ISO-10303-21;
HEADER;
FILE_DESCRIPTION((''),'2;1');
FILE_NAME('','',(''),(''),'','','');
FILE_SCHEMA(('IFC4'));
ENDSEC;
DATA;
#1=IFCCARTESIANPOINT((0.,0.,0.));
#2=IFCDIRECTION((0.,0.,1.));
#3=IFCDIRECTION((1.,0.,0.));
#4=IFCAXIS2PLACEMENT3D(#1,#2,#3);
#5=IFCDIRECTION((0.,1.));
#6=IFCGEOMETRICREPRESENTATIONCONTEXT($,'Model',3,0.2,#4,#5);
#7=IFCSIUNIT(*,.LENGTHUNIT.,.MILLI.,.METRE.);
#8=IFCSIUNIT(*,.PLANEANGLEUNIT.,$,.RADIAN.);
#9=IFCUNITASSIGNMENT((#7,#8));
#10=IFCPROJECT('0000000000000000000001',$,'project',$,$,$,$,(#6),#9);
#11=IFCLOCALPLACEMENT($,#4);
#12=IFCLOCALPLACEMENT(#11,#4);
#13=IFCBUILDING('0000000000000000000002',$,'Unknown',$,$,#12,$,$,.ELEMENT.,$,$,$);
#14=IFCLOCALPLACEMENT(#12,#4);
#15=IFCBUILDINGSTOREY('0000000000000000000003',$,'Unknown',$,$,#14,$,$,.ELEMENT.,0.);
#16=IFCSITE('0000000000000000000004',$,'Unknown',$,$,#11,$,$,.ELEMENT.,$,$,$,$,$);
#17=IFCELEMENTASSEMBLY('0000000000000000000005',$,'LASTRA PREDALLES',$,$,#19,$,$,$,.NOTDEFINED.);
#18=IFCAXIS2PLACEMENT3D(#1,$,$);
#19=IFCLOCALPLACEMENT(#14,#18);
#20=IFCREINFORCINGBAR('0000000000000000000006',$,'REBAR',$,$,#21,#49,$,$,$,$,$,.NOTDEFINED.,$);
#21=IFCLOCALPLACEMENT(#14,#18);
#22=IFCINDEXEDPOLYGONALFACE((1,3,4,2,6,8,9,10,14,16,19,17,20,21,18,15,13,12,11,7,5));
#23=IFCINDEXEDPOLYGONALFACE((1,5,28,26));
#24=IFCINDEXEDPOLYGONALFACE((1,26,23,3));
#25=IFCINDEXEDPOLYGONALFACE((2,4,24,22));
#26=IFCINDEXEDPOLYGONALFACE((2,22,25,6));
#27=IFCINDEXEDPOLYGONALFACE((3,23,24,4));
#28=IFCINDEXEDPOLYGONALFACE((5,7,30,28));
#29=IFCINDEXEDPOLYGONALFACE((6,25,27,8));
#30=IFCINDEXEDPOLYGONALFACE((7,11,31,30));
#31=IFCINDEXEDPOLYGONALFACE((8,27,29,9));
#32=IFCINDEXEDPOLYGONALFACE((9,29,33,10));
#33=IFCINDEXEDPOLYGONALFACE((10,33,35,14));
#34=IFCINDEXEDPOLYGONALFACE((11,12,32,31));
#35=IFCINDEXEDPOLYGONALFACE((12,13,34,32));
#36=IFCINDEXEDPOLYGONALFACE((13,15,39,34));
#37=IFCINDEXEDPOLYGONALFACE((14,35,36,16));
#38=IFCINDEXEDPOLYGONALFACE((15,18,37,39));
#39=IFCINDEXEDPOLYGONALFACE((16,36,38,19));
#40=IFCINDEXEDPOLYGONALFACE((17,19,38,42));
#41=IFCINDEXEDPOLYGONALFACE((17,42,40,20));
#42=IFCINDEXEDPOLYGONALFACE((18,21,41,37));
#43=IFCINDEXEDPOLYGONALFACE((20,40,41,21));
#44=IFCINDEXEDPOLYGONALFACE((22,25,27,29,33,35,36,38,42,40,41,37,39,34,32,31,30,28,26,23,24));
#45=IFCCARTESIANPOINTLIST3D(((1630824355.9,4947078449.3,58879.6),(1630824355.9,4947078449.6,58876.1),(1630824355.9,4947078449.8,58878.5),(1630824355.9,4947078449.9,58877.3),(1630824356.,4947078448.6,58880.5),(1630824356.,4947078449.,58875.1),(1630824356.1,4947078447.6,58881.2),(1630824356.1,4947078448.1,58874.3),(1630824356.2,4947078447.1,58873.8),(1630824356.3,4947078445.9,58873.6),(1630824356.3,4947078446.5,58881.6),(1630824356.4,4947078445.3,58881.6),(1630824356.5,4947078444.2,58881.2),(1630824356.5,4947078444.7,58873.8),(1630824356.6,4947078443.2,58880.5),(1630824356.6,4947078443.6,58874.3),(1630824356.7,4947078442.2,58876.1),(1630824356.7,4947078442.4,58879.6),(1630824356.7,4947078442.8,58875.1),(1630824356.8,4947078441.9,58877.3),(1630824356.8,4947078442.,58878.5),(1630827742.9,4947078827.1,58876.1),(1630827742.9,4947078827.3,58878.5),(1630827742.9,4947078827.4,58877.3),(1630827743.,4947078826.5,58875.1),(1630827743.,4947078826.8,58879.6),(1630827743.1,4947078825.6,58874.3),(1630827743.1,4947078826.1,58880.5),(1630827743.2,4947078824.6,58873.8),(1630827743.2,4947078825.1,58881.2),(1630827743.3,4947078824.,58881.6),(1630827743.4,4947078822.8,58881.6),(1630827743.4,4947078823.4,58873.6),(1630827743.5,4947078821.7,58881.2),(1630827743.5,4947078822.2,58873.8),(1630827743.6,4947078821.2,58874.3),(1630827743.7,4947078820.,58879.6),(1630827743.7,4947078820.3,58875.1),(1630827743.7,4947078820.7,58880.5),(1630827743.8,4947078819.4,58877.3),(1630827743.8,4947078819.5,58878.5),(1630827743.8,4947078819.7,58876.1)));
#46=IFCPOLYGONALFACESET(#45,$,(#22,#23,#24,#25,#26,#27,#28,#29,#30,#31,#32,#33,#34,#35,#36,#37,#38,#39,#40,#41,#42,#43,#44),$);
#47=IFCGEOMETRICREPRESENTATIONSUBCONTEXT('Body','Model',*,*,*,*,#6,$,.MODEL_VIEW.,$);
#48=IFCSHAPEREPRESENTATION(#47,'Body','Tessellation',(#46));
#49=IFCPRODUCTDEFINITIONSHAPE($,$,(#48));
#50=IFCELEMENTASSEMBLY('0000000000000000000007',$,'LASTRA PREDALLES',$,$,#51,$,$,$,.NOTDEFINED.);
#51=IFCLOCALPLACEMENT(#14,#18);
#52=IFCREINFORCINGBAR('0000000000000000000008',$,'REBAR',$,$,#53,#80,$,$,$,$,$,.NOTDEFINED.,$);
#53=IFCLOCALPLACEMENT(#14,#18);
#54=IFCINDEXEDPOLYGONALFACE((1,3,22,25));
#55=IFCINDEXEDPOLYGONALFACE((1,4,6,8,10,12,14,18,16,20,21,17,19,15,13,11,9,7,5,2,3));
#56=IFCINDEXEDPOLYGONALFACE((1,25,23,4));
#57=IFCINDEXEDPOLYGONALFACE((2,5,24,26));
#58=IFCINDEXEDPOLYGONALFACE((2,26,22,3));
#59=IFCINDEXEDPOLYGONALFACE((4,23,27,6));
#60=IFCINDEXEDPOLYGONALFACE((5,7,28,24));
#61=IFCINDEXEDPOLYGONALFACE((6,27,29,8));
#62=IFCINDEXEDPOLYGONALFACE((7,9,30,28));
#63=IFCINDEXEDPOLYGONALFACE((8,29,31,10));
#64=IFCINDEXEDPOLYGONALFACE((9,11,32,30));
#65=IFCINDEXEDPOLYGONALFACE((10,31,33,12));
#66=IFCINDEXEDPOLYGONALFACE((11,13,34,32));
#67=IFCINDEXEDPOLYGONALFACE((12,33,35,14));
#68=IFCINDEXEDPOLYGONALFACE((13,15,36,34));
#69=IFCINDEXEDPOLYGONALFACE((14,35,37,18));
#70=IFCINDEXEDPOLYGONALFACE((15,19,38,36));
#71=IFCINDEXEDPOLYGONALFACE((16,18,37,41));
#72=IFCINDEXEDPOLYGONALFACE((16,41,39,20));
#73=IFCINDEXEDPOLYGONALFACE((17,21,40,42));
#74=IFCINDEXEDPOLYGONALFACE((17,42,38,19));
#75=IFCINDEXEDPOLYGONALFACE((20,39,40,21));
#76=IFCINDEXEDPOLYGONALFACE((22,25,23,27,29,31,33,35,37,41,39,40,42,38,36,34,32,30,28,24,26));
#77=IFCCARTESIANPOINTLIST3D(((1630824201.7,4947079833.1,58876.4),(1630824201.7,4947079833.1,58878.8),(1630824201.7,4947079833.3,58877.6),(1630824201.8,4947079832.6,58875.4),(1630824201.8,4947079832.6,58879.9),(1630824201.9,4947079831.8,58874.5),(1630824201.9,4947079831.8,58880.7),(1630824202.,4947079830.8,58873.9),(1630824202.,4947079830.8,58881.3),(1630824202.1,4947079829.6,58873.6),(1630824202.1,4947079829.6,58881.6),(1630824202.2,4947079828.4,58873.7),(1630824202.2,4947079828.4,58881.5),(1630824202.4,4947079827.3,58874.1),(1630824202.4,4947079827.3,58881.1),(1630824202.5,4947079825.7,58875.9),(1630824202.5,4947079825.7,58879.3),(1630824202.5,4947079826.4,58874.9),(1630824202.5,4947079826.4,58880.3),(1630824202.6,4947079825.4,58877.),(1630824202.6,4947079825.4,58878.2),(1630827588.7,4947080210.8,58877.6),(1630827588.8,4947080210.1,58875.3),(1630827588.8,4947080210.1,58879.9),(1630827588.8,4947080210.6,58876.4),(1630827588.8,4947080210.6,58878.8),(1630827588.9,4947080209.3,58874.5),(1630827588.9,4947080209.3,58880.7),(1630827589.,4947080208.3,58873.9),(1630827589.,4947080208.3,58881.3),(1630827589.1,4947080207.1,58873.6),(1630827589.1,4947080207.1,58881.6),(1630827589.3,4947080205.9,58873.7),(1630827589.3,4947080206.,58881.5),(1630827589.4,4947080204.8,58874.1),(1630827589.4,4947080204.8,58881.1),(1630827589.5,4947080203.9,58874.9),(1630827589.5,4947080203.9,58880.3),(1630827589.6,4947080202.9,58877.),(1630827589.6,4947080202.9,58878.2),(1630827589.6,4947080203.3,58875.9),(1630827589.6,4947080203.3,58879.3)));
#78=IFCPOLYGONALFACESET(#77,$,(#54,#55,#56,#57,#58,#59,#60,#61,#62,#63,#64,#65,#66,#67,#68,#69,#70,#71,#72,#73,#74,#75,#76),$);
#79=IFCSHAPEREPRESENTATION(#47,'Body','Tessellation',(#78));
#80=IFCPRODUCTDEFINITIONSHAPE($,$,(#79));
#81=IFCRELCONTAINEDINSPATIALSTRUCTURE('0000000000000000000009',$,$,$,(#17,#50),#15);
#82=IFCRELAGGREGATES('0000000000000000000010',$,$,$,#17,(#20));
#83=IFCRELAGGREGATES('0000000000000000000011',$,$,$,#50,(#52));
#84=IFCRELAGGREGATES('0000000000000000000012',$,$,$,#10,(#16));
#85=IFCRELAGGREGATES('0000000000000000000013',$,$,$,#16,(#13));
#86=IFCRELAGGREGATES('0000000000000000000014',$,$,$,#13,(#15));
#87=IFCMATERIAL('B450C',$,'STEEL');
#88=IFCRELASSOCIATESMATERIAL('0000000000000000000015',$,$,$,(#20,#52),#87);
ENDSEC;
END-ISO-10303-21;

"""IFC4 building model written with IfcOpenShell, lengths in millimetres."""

from ifc_helpers import new_model, entity, si_unit, direction, frame, origin_with_axes, place, context, subcontext, project, spatial, material, element, aggregate, save


model = new_model("IFC4")

# Units and contexts
model_context = context("Model", 3, precision=0.2, world=origin_with_axes(), true_north=direction((0.0, 1.0)))
body_context = subcontext(model_context, "Body", "Model", "MODEL_VIEW")
ifc_project = project(units=[si_unit("LENGTHUNIT", "METRE", prefix="MILLI"), si_unit("PLANEANGLEUNIT", "RADIAN")], contexts=[model_context])

# Site, building, storey
site_placement = place(None, origin_with_axes())
site = spatial("IfcSite", under=ifc_project, at=site_placement, Name="Unknown", CompositionType="ELEMENT")
building_placement = place(site_placement, origin_with_axes())
building = spatial("IfcBuilding", under=site, at=building_placement, Name="Unknown", CompositionType="ELEMENT")
storey_placement = place(building_placement, origin_with_axes())
storey = spatial("IfcBuildingStorey", under=building, at=storey_placement, Name="Unknown", CompositionType="ELEMENT", Elevation=0.0)

# Element assemblies, reinforcing bars
ifc_material = material(Name="B450C", Category="STEEL")
assembly_1_placement = place(storey_placement, frame((1630827732.7, 4947078918.8, 58886.6), z_axis=(-0.110766, 0.993847, 0.0), x_axis=(0.0, 0.0, -1.0)))
assembly_1 = element("IfcElementAssembly", 1, at=assembly_1_placement, inside=storey, Name="LASTRA PREDALLES", PredefinedType="NOTDEFINED")
reinforcing_bar_1_placement = place(assembly_1_placement, frame((9.0, 0.0, -96.0), z_axis=(1.0, 0.0, -0.000283), x_axis=(-0.000005, 1.0, -0.000006)))
reinforcing_bar_1 = element("IfcReinforcingBar", 2, at=reinforcing_bar_1_placement, material=ifc_material, Name="REBAR", PredefinedType="NOTDEFINED", context=body_context, shape_type="AdvancedSweptSolid", body=[
    entity("IfcSweptDiskSolid", entity("IfcIndexedPolyCurve", entity("IfcCartesianPointList3D", [[0.0, 0.0, 0.0], [3408.0, 0.0, 0.0]]), [entity("IfcLineIndex", [1, 2])]), 4.0),
])
aggregate(assembly_1, [reinforcing_bar_1])
assembly_2_placement = place(storey_placement, frame((1630827599.8, 4947080111.5, 58886.6), z_axis=(-0.110766, 0.993847, 0.0), x_axis=(0.0, 0.0, -1.0)))
assembly_2 = element("IfcElementAssembly", 3, at=assembly_2_placement, inside=storey, Name="LASTRA PREDALLES", PredefinedType="NOTDEFINED")
reinforcing_bar_2_placement = place(assembly_2_placement, frame((9.0, 0.0, 96.0), z_axis=(1.0, 0.0, -0.000283), x_axis=(-0.000005, 1.0, -0.000006)))
reinforcing_bar_2 = element("IfcReinforcingBar", 4, at=reinforcing_bar_2_placement, material=ifc_material, Name="REBAR", PredefinedType="NOTDEFINED", context=body_context, shape_type="AdvancedSweptSolid", body=[
    entity("IfcSweptDiskSolid", entity("IfcIndexedPolyCurve", entity("IfcCartesianPointList3D", [[0.0, 0.0, 0.0], [3408.0, 0.0, 0.0]]), [entity("IfcLineIndex", [1, 2])]), 4.0),
])
aggregate(assembly_2, [reinforcing_bar_2])

save(model, "model.ifc")
